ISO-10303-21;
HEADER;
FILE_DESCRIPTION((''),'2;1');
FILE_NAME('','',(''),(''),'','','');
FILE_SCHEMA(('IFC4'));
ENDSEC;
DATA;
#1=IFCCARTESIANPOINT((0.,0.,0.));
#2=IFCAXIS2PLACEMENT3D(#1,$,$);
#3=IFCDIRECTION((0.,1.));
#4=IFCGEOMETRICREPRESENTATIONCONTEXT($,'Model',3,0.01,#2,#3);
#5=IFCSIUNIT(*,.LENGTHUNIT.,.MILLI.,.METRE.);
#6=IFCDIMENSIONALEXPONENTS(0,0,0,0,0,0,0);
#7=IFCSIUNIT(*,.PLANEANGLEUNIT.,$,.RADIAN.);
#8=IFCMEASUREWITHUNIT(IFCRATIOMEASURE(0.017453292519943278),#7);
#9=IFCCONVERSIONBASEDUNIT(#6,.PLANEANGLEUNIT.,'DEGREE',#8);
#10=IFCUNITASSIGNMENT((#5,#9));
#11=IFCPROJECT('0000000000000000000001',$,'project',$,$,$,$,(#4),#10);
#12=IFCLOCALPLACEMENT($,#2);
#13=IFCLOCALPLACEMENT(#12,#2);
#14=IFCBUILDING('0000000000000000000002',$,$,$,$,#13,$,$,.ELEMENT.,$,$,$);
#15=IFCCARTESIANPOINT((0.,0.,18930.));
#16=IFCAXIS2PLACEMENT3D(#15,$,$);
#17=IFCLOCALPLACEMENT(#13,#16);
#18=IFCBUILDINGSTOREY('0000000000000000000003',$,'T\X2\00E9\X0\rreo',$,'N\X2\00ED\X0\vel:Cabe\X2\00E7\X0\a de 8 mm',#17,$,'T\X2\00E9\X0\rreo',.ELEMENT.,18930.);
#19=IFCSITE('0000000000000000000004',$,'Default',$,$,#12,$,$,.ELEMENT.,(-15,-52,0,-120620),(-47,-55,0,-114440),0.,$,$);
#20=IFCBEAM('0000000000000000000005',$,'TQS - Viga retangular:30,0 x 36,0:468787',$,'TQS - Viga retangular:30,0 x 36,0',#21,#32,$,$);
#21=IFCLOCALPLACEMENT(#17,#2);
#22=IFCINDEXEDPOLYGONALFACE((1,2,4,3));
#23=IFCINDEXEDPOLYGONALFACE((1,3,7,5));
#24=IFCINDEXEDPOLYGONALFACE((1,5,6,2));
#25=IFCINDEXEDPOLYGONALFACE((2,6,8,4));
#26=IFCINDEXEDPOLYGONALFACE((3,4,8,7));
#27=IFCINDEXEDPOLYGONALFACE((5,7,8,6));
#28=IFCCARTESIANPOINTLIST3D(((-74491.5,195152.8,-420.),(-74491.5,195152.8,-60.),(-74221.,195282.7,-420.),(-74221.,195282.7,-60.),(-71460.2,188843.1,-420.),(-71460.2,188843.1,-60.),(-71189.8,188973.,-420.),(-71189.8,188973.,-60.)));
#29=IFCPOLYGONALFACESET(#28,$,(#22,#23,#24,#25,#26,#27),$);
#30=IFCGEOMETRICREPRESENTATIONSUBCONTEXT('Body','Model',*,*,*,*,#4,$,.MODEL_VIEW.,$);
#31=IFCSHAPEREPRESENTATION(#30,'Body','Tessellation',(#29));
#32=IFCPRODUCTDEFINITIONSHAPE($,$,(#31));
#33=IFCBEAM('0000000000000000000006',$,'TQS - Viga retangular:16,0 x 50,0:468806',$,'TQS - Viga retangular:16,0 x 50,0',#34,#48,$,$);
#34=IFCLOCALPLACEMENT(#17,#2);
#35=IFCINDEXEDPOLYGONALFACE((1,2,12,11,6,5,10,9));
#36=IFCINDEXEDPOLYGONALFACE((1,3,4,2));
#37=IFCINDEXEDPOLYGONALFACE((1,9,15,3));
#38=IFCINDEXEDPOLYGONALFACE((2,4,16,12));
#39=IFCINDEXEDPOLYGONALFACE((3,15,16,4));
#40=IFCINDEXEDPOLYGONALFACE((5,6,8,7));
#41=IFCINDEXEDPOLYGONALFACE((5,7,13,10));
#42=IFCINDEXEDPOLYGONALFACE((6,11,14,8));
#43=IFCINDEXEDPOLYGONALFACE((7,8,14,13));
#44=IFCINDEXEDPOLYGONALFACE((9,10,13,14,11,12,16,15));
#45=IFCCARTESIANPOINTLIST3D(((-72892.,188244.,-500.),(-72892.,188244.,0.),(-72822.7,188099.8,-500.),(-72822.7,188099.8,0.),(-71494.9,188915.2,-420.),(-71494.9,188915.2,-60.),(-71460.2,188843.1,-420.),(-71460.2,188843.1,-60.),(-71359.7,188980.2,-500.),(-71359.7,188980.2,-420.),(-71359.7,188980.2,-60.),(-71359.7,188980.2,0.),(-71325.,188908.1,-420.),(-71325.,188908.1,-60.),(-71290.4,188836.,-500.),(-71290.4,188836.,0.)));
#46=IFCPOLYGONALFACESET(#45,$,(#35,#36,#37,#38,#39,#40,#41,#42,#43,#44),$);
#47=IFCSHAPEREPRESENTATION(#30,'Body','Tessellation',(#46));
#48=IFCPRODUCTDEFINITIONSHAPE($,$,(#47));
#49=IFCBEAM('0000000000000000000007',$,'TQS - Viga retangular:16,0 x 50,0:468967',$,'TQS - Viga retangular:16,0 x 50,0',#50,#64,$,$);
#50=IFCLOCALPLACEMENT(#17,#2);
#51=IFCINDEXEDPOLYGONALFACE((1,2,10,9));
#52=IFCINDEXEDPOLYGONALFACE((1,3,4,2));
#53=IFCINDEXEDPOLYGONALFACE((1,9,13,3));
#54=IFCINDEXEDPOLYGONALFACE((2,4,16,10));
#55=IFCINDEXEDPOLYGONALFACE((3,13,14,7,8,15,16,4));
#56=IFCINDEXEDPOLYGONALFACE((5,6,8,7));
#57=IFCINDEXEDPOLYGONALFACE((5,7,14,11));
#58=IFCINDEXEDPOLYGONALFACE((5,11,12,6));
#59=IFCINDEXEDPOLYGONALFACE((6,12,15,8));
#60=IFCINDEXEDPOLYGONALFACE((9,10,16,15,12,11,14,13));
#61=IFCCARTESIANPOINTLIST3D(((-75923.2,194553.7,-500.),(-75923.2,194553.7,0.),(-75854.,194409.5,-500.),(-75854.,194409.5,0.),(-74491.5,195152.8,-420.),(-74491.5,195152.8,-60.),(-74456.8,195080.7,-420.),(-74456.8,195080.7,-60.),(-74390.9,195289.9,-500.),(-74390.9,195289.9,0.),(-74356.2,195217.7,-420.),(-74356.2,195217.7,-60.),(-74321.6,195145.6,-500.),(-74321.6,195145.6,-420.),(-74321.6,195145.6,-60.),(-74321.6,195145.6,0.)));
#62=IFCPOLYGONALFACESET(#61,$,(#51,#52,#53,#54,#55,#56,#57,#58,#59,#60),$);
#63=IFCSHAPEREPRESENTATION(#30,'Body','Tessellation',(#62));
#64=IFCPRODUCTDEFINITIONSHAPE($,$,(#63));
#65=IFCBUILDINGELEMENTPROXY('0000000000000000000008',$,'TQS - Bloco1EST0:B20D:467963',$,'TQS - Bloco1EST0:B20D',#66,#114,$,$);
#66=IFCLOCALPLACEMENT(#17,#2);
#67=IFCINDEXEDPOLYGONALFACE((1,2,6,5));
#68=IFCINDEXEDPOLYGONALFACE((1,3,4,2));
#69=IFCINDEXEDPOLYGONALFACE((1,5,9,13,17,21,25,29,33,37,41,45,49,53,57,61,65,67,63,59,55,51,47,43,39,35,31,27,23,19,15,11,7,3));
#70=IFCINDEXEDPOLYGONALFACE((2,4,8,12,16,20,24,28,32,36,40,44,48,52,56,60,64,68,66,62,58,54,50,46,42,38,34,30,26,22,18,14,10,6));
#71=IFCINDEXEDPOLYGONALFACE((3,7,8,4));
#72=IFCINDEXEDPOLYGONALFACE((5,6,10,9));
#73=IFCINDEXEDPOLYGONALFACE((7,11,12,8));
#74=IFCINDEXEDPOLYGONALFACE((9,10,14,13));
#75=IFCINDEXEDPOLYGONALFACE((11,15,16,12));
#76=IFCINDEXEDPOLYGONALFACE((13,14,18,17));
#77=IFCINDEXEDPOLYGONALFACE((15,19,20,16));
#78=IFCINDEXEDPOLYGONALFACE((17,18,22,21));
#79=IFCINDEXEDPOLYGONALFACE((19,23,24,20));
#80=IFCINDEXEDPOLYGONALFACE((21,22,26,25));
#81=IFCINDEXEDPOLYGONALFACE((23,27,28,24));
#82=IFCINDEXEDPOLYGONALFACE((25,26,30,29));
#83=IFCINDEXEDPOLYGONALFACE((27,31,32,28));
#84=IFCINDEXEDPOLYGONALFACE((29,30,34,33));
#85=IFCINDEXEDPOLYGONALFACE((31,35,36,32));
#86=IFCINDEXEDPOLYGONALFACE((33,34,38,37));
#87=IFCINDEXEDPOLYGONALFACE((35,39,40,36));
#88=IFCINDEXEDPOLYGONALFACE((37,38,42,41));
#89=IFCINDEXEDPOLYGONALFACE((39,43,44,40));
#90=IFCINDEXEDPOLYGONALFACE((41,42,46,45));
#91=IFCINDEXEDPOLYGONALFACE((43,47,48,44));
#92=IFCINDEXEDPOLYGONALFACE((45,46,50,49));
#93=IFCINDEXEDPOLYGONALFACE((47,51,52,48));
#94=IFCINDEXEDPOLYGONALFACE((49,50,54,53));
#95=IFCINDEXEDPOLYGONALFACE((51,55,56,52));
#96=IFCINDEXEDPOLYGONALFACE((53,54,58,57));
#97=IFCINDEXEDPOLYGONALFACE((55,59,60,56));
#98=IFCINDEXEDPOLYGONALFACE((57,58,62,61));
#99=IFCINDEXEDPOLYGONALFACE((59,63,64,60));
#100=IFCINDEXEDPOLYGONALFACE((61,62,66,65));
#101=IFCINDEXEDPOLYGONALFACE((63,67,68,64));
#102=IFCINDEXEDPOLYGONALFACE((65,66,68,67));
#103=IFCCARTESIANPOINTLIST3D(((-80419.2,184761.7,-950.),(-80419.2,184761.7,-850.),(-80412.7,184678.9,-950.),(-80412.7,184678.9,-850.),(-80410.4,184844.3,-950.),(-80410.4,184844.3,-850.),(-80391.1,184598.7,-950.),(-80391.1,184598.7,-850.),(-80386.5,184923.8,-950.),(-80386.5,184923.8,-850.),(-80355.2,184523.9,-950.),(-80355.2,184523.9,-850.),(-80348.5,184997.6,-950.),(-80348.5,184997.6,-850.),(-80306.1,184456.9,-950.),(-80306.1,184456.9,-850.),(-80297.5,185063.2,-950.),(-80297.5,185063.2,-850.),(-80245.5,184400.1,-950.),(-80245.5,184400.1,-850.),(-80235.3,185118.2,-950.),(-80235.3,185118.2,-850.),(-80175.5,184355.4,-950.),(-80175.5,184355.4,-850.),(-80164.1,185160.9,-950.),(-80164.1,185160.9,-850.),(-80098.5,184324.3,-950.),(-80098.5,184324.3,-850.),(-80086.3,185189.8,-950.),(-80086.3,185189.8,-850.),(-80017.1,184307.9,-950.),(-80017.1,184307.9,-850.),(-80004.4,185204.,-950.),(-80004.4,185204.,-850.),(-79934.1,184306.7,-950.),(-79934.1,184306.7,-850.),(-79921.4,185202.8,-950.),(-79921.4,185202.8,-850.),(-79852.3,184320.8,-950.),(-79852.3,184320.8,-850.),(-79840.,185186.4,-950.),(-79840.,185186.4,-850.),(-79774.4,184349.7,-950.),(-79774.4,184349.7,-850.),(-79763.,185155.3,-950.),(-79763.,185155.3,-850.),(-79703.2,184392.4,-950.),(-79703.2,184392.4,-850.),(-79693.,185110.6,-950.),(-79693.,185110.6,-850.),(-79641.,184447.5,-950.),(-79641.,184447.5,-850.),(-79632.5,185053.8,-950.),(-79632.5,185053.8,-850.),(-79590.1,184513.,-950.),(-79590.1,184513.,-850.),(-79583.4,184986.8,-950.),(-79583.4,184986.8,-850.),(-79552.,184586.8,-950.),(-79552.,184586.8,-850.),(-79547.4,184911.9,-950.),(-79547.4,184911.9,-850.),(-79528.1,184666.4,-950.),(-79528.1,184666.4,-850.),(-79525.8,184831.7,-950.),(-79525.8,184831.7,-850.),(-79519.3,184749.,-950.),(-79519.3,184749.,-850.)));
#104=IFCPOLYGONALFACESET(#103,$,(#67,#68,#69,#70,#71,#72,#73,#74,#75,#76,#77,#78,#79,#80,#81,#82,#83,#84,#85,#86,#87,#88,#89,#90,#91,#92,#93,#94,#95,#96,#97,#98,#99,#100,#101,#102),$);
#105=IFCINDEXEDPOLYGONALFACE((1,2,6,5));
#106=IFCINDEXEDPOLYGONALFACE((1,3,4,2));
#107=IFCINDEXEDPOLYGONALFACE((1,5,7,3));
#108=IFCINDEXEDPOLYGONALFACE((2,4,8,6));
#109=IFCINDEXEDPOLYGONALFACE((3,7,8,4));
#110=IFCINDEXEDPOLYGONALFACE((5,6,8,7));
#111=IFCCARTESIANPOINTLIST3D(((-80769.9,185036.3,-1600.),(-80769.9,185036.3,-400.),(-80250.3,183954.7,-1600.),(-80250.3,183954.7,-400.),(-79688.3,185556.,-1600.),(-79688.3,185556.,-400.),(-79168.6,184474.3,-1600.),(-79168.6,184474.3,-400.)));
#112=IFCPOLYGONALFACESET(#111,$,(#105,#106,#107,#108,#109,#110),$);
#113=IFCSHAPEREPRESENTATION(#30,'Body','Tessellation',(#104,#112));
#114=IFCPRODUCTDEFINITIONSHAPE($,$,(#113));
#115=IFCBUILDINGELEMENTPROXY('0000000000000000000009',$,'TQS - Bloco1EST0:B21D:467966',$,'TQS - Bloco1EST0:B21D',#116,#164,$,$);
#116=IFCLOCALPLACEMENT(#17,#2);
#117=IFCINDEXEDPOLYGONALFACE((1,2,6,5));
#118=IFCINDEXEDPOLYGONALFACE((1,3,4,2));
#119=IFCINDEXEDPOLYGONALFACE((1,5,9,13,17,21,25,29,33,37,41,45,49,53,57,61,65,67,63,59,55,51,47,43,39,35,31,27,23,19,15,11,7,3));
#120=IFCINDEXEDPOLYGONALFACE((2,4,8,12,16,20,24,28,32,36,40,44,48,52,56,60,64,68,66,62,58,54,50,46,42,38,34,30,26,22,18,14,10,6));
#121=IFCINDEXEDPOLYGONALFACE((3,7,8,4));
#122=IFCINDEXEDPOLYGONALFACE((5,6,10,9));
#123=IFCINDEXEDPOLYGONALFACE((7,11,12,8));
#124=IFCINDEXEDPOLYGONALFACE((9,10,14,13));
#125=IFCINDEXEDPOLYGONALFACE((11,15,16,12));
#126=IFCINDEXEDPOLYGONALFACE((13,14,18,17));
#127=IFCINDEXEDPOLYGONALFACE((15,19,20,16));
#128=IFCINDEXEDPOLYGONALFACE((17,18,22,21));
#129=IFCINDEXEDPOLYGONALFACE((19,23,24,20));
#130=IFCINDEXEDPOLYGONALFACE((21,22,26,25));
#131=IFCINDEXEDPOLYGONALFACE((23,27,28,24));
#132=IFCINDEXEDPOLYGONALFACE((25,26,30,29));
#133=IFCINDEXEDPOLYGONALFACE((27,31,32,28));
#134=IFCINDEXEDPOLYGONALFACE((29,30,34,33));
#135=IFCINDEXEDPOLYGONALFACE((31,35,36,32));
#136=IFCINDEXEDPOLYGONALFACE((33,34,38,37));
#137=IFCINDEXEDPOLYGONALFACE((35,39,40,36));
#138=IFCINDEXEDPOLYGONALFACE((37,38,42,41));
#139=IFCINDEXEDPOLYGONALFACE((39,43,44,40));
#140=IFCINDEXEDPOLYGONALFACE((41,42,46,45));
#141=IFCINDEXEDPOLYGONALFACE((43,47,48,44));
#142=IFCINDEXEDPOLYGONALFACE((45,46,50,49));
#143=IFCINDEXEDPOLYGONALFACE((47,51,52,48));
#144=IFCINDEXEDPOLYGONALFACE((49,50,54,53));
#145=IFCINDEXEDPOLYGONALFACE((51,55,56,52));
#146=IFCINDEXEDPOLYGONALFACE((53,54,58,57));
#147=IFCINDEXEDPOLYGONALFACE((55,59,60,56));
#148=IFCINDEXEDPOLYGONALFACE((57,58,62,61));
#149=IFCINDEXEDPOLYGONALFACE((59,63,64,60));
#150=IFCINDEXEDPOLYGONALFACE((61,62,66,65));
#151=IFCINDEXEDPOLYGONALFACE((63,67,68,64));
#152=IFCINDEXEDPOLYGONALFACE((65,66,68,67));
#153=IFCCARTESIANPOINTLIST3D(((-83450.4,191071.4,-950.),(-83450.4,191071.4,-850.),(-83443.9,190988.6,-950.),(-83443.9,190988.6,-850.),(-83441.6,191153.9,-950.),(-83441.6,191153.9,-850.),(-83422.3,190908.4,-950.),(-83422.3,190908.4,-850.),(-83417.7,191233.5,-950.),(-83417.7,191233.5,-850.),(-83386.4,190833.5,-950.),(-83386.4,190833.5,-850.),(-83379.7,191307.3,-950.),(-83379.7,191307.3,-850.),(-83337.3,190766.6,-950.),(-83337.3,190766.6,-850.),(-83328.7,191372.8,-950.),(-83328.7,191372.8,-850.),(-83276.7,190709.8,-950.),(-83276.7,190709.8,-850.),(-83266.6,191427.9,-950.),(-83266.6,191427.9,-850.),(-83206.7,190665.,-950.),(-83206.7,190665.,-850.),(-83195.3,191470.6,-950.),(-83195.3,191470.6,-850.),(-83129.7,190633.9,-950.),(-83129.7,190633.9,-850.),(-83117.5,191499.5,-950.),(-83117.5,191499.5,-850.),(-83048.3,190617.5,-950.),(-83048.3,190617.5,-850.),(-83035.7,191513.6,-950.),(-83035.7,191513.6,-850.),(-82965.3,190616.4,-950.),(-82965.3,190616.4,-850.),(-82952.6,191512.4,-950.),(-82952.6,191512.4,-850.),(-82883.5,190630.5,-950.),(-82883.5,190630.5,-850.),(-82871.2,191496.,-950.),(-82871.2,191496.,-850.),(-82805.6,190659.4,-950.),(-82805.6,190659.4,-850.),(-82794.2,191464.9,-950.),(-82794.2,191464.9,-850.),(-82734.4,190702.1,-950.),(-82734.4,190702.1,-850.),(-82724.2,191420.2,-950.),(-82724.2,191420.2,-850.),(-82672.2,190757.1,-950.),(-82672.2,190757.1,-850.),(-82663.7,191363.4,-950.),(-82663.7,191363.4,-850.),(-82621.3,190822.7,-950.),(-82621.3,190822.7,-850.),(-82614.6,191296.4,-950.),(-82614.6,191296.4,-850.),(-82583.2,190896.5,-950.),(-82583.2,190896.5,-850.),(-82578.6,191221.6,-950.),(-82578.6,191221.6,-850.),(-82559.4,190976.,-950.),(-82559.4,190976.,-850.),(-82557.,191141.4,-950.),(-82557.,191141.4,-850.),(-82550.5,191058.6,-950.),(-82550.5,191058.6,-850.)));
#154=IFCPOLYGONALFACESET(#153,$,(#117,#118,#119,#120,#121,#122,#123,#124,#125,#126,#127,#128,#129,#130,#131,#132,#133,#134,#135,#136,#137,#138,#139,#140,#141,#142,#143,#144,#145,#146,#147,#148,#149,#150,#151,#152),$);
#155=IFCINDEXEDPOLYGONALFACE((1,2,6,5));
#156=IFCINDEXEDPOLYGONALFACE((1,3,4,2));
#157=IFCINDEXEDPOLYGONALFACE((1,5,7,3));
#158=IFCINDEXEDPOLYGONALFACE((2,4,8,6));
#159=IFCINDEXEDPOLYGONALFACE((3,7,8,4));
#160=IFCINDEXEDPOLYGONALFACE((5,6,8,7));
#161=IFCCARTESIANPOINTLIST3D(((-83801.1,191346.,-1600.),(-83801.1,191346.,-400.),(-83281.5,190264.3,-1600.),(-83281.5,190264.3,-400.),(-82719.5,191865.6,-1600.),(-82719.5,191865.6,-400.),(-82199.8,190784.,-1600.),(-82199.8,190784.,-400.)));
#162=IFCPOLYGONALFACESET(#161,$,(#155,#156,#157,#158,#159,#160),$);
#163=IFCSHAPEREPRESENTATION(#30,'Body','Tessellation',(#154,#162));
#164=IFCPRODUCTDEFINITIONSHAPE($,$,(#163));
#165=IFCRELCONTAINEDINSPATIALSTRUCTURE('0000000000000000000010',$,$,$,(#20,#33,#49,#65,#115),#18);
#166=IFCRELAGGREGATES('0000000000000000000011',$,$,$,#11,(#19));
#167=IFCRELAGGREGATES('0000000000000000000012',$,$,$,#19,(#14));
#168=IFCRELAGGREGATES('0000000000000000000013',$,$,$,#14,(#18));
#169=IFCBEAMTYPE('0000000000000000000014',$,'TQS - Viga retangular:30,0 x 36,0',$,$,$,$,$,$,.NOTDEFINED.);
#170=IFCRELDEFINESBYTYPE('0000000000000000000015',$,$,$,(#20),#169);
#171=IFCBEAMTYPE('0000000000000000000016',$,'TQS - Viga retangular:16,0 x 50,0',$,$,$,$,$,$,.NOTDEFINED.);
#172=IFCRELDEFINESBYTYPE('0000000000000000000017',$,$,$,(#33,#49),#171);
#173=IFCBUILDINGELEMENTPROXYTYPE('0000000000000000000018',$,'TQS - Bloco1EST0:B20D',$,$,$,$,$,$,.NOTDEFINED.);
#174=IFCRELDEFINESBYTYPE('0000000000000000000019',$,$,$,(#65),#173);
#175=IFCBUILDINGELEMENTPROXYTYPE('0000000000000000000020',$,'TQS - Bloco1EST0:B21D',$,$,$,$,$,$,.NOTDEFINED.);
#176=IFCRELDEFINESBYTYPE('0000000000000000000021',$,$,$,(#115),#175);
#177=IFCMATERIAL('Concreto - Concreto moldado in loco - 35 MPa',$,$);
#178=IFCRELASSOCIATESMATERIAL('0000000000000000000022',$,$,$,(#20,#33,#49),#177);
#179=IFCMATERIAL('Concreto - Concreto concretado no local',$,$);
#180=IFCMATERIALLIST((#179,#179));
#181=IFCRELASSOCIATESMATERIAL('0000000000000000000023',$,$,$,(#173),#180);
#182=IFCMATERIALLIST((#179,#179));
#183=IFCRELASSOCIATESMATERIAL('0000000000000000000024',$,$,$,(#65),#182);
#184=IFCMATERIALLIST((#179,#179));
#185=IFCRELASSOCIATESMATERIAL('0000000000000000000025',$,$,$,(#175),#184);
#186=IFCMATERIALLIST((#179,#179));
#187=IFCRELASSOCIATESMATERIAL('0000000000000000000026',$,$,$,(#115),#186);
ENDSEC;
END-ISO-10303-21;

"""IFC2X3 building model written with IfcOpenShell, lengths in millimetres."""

from ifc_helpers import new_model, entity, si_unit, converted_unit, direction, frame, frame_2d, origin, origin_2d_with_axis, place, context, subcontext, project, spatial, polyline, rectangle, circle, extrude, boolean, clip, bounded_halfspace, source, transform, mapped, material, material_list, type_object, type_shapes, element, save


model = new_model("IFC2X3")

# Units and contexts
model_context = context("Model", 3, precision=0.01, world=origin(), true_north=direction((0.0, 1.0)))
body_context = subcontext(model_context, "Body", "Model", "MODEL_VIEW")
ifc_project = project(units=[si_unit("LENGTHUNIT", "METRE", prefix="MILLI"), converted_unit("PLANEANGLEUNIT", "DEGREE", entity("IfcRatioMeasure", 0.017453292519943278), si_unit("PLANEANGLEUNIT", "RADIAN"), dimensions=[0, 0, 0, 0, 0, 0, 0])], contexts=[model_context])

# Site, building, storey
site_placement = place(None, origin())
site = spatial("IfcSite", under=ifc_project, at=site_placement, Name="Default", CompositionType="ELEMENT", RefLatitude=(-15, -52, 0, -120620), RefLongitude=(-47, -55, 0, -114440), RefElevation=0.0)
building_placement = place(site_placement, origin())
building = spatial("IfcBuilding", under=site, at=building_placement, CompositionType="ELEMENT")
storey_placement = place(building_placement, frame((0.0, 0.0, 18930.0)))
storey = spatial("IfcBuildingStorey", under=building, at=storey_placement, Name="Térreo", ObjectType="Nível:Cabeça de 8 mm", LongName="Térreo", CompositionType="ELEMENT", Elevation=18930.0)

# Beams
ifc_material_1 = material(Name="Concreto - Concreto moldado in loco - 35 MPa")
beam_type_1 = type_object("IfcBeamType", Name="TQS - Viga retangular:30,0 x 36,0", PredefinedType="NOTDEFINED")
beam_1_placement = place(storey_placement, frame((-71325.0, 188908.1, -60.0), z_axis=(0.0, 0.0, 1.0), x_axis=(-0.43303, 0.90138, 0.0)))
element("IfcBeam", 1, at=beam_1_placement, inside=storey, type_object=beam_type_1, material=ifc_material_1, Name="TQS - Viga retangular:30,0 x 36,0:468787", ObjectType="TQS - Viga retangular:30,0 x 36,0", context=body_context, shape_type="SweptSolid", body=[
    extrude(rectangle(XDim=360.0, YDim=300.0, at=frame_2d((0.0, 0.0), x_axis=(1.0, 0.0))), frame((0.0, 0.0, -180.0), z_axis=(1.0, 0.0, 0.0), x_axis=(0.0, 0.0, -1.0)), (0.0, 0.0, 1.0), 7000.0),
])
beam_type_2 = type_object("IfcBeamType", Name="TQS - Viga retangular:16,0 x 50,0", PredefinedType="NOTDEFINED")
beam_2_placement = place(storey_placement, frame((-71325.0, 188908.1, 0.0), z_axis=(0.0, 0.0, 1.0), x_axis=(-0.90138, -0.43303, 0.0)))
element("IfcBeam", 2, at=beam_2_placement, inside=storey, type_object=beam_type_2, material=ifc_material_1, Name="TQS - Viga retangular:16,0 x 50,0:468806", ObjectType="TQS - Viga retangular:16,0 x 50,0", context=body_context, shape_type="SweptSolid", body=[
    boolean("DIFFERENCE", clip(extrude(rectangle(XDim=500.0, YDim=160.0, at=frame_2d((0.0, 0.0), x_axis=(0.0, 1.0))), frame((0.0, 0.0, -250.0), z_axis=(1.0, 0.0, 0.0), x_axis=(0.0, 1.0, 0.0)), (0.0, 0.0, 1.0), 1700.0), bounded_halfspace(frame((150.0, -7000.0, -420.0), z_axis=(-1.0, 0.0, 0.0), x_axis=(0.0, 1.0, 0.0)), False, frame((0.0, 0.0, -250.0), z_axis=(1.0, 0.0, 0.0), x_axis=(0.0, 1.0, 0.0)), polyline([(0.0, 190.0), (0.0, -170.0), (-80.0, -170.0), (-80.0, 90.0), (-80.0, 190.0), (0.0, 190.0)]))), extrude(rectangle(XDim=360.0, YDim=80.0, at=frame_2d((0.0, 0.0), x_axis=(0.0, 1.0))), frame((150.0, -40.0, -240.0), z_axis=(1.0, 0.0, 0.0), x_axis=(0.0, 1.0, 0.0)), (0.0, 0.0, -1.0), 150.0)),
])
beam_3_placement = place(storey_placement, frame((-74356.2, 195217.7, 0.0), z_axis=(0.0, 0.0, 1.0), x_axis=(-0.90138, -0.43303, 0.0)))
element("IfcBeam", 3, at=beam_3_placement, inside=storey, type_object=beam_type_2, material=ifc_material_1, Name="TQS - Viga retangular:16,0 x 50,0:468967", ObjectType="TQS - Viga retangular:16,0 x 50,0", context=body_context, shape_type="SweptSolid", body=[
    boolean("DIFFERENCE", clip(extrude(rectangle(XDim=500.0, YDim=160.0, at=frame_2d((0.0, 0.0), x_axis=(1.0, 0.0))), frame((0.0, 0.0, -250.0), z_axis=(1.0, 0.0, 0.0), x_axis=(0.0, 0.0, -1.0)), (0.0, 0.0, 1.0), 1700.0), bounded_halfspace(frame((150.0, 0.0, -420.0), z_axis=(-1.0, 0.0, 0.0), x_axis=(0.0, 1.0, 0.0)), False, frame((0.0, 0.0, -250.0), z_axis=(1.0, 0.0, 0.0), x_axis=(0.0, 0.0, -1.0)), polyline([(170.0, 0.0), (-190.0, 0.0), (-190.0, 80.0), (-90.0, 80.0), (170.0, 80.0), (170.0, 0.0)]))), extrude(rectangle(XDim=360.0, YDim=80.0, at=frame_2d((0.0, 0.0), x_axis=(0.0, 1.0))), frame((0.0, 40.0, -240.0), z_axis=(-1.0, 0.0, 0.0), x_axis=(0.0, -1.0, 0.0)), (0.0, 0.0, -1.0), 150.0)),
])

# Building element proxies
ifc_material_2 = material(Name="Concreto - Concreto concretado no local")
ifc_material_list_1 = material_list([ifc_material_2, ifc_material_2])
ifc_material_list_2 = material_list([ifc_material_2, ifc_material_2])
building_element_proxy_type_1 = type_object("IfcBuildingElementProxyType", Name="TQS - Bloco1EST0:B20D", PredefinedType="NOTDEFINED", material=ifc_material_list_2)
shared_shape_1 = source(origin(), body_context, "Body", "SweptSolid", [
    extrude(circle(Radius=450.0, at=frame_2d((0.0, 0.0), x_axis=(1.0, 0.0))), frame((0.0, 0.0, -550.0)), (0.0, 0.0, 1.0), 100.0),
    extrude(rectangle(XDim=1200.0, YDim=1200.0, at=origin_2d_with_axis()), frame((0.0, 0.0, -1200.0), z_axis=(0.0, 0.0, 1.0), x_axis=(-1.0, 0.0, 0.0)), (0.0, 0.0, 1.0), 1200.0),
])
type_shapes(building_element_proxy_type_1, [shared_shape_1])
proxy_1_placement = place(storey_placement, frame((-79969.3, 184755.3, -400.0), z_axis=(0.0, 0.0, 1.0), x_axis=(-0.43303, 0.90138, 0.0)))
element("IfcBuildingElementProxy", 4, at=proxy_1_placement, inside=storey, type_object=building_element_proxy_type_1, material=ifc_material_list_1, Name="TQS - Bloco1EST0:B20D:467963", ObjectType="TQS - Bloco1EST0:B20D", context=body_context, shape_type="MappedRepresentation", body=[
    mapped(shared_shape_1, transform((0.0, 0.0, 0.0), scale=1.0)),
])
ifc_material_list_3 = material_list([ifc_material_2, ifc_material_2])
ifc_material_list_4 = material_list([ifc_material_2, ifc_material_2])
building_element_proxy_type_2 = type_object("IfcBuildingElementProxyType", Name="TQS - Bloco1EST0:B21D", PredefinedType="NOTDEFINED", material=ifc_material_list_4)
shared_shape_2 = source(origin(), body_context, "Body", "SweptSolid", [
    extrude(circle(Radius=450.0, at=frame_2d((0.0, 0.0), x_axis=(1.0, 0.0))), frame((0.0, 0.0, -550.0)), (0.0, 0.0, 1.0), 100.0),
    extrude(rectangle(XDim=1200.0, YDim=1200.0, at=origin_2d_with_axis()), frame((0.0, 0.0, -1200.0), z_axis=(0.0, 0.0, 1.0), x_axis=(-1.0, 0.0, 0.0)), (0.0, 0.0, 1.0), 1200.0),
])
type_shapes(building_element_proxy_type_2, [shared_shape_2])
proxy_2_placement = place(storey_placement, frame((-83000.5, 191065.0, -400.0), z_axis=(0.0, 0.0, 1.0), x_axis=(-0.43303, 0.90138, 0.0)))
element("IfcBuildingElementProxy", 5, at=proxy_2_placement, inside=storey, type_object=building_element_proxy_type_2, material=ifc_material_list_3, Name="TQS - Bloco1EST0:B21D:467966", ObjectType="TQS - Bloco1EST0:B21D", context=body_context, shape_type="MappedRepresentation", body=[
    mapped(shared_shape_2, transform((0.0, 0.0, 0.0), scale=1.0)),
])

save(model, "model.ifc")
